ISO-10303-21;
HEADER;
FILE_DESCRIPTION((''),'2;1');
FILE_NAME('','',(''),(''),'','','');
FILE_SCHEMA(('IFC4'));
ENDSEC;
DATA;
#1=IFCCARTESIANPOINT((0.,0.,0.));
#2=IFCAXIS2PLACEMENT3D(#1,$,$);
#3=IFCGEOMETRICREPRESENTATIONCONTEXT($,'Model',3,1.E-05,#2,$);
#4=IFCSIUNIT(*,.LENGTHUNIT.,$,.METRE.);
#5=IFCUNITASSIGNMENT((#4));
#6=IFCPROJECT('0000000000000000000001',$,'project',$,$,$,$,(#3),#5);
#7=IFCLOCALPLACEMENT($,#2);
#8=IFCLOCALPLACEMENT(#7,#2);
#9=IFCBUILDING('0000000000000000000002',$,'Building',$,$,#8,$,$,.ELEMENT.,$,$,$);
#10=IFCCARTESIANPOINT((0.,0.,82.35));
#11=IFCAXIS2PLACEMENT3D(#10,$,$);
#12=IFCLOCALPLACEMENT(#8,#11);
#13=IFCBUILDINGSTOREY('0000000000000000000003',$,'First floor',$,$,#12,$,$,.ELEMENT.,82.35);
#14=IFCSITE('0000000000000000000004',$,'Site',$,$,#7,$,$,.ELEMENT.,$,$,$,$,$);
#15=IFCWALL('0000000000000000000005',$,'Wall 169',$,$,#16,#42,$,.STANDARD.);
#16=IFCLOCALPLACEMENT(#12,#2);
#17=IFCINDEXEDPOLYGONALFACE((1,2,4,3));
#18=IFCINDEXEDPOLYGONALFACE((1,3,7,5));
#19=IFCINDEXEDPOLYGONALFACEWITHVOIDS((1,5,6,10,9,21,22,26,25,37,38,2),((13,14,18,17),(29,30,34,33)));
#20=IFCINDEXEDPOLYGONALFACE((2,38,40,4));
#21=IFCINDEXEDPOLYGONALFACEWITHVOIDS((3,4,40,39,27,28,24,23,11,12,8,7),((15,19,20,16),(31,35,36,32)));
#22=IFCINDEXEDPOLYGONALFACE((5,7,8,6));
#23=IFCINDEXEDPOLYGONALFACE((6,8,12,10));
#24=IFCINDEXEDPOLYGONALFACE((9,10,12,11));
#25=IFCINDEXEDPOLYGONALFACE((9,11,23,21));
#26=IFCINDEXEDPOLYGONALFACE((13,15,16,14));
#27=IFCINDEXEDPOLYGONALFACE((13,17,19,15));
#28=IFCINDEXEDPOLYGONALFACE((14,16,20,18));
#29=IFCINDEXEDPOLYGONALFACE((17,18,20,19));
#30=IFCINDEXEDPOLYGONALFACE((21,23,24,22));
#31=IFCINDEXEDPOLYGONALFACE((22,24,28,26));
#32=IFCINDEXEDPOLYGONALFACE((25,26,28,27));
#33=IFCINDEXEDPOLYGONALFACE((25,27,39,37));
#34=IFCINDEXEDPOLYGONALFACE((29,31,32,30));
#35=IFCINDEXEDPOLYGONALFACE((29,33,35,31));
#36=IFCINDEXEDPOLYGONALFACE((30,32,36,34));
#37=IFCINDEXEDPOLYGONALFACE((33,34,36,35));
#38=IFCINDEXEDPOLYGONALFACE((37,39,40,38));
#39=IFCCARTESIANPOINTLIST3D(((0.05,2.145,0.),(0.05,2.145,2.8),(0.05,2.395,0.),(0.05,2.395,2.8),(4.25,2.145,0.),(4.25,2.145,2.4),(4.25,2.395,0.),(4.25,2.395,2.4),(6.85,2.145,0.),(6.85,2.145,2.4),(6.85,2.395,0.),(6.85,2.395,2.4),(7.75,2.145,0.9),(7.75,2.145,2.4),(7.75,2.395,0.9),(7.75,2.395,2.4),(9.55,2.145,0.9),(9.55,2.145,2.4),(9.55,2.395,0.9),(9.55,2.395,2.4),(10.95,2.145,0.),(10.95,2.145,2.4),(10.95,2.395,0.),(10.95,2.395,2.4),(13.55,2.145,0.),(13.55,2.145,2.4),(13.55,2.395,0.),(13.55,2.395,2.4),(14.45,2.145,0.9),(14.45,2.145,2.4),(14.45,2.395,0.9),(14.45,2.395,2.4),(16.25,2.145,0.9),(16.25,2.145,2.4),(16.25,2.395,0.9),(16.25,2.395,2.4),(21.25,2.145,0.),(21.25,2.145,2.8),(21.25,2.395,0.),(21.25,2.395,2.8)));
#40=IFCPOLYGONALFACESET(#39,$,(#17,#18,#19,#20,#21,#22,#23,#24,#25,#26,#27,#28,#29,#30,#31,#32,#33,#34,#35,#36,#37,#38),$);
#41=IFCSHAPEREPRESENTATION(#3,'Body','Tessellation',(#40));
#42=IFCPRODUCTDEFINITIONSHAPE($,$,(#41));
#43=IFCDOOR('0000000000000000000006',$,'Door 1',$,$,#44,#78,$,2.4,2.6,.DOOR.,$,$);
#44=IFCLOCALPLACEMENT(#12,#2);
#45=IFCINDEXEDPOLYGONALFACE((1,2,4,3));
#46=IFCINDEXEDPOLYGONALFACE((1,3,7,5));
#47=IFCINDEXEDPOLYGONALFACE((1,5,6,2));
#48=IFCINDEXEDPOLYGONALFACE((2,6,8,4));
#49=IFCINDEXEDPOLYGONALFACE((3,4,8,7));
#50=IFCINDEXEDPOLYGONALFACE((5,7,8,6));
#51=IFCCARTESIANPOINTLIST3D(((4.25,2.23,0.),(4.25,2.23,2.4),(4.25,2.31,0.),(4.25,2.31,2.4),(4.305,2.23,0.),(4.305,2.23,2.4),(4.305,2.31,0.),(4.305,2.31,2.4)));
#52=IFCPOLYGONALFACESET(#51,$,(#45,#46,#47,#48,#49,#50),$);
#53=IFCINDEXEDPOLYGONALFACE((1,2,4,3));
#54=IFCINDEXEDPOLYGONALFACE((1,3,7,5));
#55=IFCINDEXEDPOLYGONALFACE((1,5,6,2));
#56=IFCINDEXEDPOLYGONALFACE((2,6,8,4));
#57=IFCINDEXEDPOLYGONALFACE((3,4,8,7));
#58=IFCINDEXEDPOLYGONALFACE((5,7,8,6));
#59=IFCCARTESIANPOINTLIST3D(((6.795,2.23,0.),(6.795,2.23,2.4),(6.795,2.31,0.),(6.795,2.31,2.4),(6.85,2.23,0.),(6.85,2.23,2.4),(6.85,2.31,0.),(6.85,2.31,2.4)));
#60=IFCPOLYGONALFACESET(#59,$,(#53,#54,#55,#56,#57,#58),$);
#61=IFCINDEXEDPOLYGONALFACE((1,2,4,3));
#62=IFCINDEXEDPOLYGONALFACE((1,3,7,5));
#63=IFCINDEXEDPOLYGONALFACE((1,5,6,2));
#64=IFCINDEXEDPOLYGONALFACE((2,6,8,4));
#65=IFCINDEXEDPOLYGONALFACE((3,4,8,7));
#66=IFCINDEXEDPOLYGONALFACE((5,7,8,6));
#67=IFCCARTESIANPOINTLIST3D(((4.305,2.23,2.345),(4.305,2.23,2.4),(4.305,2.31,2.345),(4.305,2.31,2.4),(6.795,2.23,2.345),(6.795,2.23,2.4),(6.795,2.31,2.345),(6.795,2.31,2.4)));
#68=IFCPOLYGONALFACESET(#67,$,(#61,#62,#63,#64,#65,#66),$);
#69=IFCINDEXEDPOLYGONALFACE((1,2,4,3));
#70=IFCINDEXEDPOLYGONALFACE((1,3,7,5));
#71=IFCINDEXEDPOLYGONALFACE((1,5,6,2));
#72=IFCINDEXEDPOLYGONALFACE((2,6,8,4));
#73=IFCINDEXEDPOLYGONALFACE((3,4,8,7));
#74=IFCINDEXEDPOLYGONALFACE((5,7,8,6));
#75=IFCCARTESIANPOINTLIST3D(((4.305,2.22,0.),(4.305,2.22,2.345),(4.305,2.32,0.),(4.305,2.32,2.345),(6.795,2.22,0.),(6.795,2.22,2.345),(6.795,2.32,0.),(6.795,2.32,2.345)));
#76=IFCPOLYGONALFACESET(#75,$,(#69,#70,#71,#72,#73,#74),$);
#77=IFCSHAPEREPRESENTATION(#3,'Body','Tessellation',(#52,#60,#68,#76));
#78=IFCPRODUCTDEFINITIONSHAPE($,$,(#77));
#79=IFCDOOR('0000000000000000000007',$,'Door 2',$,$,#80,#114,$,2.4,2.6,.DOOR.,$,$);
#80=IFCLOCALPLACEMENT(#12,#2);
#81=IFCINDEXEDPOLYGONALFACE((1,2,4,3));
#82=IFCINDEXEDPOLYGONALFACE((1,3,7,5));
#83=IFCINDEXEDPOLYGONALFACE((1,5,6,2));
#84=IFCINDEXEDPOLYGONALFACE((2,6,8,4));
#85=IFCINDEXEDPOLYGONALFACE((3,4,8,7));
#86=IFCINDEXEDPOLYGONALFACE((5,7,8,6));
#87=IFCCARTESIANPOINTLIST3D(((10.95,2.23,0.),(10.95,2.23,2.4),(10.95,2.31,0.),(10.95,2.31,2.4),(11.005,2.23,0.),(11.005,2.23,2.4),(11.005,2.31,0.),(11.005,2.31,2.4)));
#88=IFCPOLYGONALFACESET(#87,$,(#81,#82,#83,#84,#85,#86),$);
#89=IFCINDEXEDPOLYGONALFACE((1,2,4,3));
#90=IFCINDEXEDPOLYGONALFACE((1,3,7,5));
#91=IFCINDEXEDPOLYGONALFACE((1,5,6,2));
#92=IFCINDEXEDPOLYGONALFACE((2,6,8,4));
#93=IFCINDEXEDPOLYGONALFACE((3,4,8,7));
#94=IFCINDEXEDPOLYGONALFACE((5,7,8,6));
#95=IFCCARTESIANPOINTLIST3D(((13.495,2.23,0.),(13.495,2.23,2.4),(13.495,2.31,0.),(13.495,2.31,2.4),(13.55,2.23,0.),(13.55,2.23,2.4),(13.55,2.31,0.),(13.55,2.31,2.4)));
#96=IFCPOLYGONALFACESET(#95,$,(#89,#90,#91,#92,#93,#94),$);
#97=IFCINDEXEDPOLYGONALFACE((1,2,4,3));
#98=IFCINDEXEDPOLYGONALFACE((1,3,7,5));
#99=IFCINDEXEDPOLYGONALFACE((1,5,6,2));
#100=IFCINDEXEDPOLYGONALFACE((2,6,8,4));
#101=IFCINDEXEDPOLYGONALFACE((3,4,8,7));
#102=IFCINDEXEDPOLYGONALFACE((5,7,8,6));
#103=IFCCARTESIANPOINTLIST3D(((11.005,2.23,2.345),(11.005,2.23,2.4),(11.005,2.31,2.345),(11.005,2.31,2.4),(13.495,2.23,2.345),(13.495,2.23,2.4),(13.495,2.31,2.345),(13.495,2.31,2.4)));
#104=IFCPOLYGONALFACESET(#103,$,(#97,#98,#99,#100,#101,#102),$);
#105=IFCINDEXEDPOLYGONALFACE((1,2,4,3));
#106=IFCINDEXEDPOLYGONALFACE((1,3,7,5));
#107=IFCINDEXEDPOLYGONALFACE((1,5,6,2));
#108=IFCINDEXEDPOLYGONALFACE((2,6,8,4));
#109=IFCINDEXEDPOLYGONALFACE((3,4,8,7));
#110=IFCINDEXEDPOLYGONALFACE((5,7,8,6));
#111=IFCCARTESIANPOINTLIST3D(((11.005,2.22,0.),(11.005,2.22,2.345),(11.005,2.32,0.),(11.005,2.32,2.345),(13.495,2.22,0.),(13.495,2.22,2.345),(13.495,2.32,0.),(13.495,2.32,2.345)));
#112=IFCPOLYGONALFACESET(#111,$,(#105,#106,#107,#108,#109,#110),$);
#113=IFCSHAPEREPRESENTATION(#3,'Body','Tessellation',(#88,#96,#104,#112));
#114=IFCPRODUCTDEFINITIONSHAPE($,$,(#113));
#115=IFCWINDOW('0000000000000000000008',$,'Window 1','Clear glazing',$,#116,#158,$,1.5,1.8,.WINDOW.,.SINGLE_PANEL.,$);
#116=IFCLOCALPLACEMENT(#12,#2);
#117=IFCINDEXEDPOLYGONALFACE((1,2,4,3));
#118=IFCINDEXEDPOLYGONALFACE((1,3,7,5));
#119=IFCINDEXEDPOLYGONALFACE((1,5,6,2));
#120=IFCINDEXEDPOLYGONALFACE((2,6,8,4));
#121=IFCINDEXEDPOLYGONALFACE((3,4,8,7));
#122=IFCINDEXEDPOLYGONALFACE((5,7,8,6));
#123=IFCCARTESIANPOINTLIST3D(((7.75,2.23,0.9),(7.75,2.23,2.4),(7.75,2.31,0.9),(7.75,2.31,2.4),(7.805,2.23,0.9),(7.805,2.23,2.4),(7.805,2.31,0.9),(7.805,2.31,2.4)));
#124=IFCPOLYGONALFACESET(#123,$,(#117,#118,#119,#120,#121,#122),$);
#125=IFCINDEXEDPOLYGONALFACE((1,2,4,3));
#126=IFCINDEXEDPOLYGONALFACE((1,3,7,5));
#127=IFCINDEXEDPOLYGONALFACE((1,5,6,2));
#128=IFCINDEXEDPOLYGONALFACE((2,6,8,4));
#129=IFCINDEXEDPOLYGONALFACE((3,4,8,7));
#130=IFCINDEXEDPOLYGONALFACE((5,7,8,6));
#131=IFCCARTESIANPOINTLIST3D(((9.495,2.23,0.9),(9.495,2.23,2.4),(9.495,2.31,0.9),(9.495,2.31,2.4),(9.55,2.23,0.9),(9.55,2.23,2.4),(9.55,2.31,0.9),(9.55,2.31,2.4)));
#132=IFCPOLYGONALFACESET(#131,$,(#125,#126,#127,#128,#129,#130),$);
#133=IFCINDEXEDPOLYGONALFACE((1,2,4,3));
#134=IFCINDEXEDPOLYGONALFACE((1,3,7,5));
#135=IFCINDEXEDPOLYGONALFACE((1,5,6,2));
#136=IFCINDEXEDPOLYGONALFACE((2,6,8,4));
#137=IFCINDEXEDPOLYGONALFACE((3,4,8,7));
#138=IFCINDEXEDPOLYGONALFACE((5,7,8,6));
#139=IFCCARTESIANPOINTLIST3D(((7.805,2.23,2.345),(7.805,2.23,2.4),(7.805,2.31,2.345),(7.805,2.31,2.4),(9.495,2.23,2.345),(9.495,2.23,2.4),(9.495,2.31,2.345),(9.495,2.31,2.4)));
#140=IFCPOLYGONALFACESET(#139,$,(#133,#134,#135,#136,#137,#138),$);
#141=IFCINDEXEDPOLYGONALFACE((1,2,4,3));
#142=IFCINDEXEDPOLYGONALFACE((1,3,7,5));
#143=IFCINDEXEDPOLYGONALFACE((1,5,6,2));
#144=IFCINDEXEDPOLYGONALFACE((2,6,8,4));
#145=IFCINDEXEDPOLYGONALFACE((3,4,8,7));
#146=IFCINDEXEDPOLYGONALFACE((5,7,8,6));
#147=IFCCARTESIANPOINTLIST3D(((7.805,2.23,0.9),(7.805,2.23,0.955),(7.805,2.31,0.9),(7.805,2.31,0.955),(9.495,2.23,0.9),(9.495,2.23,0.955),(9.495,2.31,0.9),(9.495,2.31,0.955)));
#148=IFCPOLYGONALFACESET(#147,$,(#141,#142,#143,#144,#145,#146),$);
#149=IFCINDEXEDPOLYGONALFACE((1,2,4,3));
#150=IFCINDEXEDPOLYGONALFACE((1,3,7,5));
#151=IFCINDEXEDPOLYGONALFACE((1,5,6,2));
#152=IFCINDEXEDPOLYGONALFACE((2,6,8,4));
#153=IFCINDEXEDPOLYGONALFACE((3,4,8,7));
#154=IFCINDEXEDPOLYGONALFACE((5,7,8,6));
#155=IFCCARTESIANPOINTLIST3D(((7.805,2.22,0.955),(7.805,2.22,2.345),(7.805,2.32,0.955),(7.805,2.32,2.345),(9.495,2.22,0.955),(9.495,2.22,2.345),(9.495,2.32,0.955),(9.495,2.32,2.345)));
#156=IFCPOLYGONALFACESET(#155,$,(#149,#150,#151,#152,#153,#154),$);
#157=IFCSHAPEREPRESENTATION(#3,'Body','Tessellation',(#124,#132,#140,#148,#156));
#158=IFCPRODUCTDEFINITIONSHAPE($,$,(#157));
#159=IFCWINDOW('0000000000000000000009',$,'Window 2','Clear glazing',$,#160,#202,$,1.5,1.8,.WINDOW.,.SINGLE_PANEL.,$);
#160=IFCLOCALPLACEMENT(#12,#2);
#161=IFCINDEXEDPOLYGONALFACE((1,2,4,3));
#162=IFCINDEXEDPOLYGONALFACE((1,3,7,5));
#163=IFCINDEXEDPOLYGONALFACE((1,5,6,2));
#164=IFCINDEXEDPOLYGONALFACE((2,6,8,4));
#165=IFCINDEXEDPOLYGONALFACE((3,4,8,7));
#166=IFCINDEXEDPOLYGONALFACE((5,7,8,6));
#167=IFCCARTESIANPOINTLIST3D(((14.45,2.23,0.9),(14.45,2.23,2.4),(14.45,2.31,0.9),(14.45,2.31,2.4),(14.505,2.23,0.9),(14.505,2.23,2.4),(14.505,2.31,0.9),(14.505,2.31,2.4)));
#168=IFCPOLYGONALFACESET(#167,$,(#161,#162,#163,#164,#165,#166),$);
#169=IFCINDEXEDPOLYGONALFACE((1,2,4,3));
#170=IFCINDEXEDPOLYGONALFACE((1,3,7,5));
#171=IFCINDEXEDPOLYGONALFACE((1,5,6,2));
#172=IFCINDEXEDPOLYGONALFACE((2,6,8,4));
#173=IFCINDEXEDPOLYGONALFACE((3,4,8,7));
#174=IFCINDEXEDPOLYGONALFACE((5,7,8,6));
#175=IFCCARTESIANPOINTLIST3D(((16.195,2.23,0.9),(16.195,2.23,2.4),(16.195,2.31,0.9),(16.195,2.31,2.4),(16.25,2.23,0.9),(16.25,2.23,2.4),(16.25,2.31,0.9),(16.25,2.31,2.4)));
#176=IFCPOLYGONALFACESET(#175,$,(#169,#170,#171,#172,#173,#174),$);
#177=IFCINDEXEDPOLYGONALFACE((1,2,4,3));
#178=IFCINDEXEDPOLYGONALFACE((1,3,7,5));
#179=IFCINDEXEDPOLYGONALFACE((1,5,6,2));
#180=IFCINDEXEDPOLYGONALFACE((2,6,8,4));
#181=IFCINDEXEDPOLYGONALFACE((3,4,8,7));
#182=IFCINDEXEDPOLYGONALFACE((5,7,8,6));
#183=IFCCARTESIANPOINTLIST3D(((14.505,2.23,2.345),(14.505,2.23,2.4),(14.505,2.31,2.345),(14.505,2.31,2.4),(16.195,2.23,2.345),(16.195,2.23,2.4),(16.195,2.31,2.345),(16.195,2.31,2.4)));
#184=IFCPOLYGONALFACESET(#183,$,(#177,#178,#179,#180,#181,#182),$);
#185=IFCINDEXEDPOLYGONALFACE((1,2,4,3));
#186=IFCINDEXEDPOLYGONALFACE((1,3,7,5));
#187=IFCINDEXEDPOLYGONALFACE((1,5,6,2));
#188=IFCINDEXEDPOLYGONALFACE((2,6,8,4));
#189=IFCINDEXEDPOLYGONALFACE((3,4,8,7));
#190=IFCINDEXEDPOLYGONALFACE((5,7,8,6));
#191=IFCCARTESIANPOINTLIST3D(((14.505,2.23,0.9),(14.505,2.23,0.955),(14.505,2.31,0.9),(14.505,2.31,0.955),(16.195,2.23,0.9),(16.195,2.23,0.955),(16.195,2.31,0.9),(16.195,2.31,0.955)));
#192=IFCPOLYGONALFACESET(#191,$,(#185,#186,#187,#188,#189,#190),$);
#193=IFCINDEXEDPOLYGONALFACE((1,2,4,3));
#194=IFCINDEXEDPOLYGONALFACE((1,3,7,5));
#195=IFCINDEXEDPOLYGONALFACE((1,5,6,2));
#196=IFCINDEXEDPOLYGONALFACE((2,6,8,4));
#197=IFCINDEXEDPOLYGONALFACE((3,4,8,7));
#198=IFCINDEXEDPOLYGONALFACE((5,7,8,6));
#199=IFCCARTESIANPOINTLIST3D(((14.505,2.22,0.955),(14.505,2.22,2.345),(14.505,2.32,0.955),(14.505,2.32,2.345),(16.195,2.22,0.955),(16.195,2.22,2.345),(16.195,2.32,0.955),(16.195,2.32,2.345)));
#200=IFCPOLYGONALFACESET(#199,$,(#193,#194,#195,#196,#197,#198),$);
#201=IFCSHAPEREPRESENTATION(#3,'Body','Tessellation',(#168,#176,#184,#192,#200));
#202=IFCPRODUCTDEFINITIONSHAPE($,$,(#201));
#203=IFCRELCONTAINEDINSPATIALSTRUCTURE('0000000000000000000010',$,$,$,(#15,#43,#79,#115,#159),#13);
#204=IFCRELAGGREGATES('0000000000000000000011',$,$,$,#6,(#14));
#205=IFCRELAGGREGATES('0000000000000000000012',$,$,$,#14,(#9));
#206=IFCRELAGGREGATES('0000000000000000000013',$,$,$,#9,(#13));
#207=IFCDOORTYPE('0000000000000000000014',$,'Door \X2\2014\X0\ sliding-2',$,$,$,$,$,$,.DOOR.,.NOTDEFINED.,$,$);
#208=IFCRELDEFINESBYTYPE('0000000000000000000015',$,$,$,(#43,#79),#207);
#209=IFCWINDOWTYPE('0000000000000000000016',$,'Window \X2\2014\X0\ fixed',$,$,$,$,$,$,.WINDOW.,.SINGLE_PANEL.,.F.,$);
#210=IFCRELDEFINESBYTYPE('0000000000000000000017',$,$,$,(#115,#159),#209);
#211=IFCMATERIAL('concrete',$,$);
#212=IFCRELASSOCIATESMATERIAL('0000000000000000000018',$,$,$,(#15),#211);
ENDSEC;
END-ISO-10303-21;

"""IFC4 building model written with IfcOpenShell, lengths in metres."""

from ifc_helpers import new_model, si_unit, frame, frame_2d, origin, place, context, project, spatial, rectangle, extrude, material, type_object, element, fill, save


model = new_model("IFC4")

# Units and contexts
model_context = context("Model", 3, precision=1e-05, world=origin())
ifc_project = project(units=[si_unit("LENGTHUNIT", "METRE")], contexts=[model_context])

# Site, building, storey
site_placement = place(None, origin())
site = spatial("IfcSite", under=ifc_project, at=site_placement, Name="Site", CompositionType="ELEMENT")
building_placement = place(site_placement, origin())
building = spatial("IfcBuilding", under=site, at=building_placement, Name="Building", CompositionType="ELEMENT")
storey_placement = place(building_placement, frame((0.0, 0.0, 82.35)))
storey = spatial("IfcBuildingStorey", under=building, at=storey_placement, Name="First floor", CompositionType="ELEMENT", Elevation=82.35)

# Shared definitions
ifc_material = material(Name="concrete")

# Wall, openings, doors, windows
wall_1_placement = place(storey_placement, frame((0.05, 2.27, 0.0), z_axis=(0.0, 0.0, 1.0), x_axis=(1.0, 0.0, 0.0)))
wall_1 = element("IfcWall", 1, at=wall_1_placement, inside=storey, material=ifc_material, Name="Wall 169", PredefinedType="STANDARD", context=model_context, shape_type="SweptSolid", body=[
    extrude(rectangle(XDim=21.2, YDim=0.25, at=frame_2d((10.6, 0.0))), origin(), (0.0, 0.0, 1.0), 2.8),
])
opening_1_placement = place(storey_placement, frame((4.25, 2.27, 0.0), z_axis=(0.0, 0.0, 1.0), x_axis=(1.0, 0.0, 0.0)))
opening_1 = element("IfcOpeningElement", 2, at=opening_1_placement, cuts=wall_1, PredefinedType="OPENING", context=model_context, shape_type="SweptSolid", body=[
    extrude(rectangle(XDim=2.6, YDim=0.31, at=frame_2d((1.3, 0.0))), origin(), (0.0, 0.0, 1.0), 2.4),
])
opening_2_placement = place(storey_placement, frame((7.75, 2.27, 0.9), z_axis=(0.0, 0.0, 1.0), x_axis=(1.0, 0.0, 0.0)))
opening_2 = element("IfcOpeningElement", 3, at=opening_2_placement, cuts=wall_1, PredefinedType="OPENING", context=model_context, shape_type="SweptSolid", body=[
    extrude(rectangle(XDim=1.8, YDim=0.31, at=frame_2d((0.9, 0.0))), origin(), (0.0, 0.0, 1.0), 1.5),
])
opening_3_placement = place(storey_placement, frame((10.95, 2.27, 0.0), z_axis=(0.0, 0.0, 1.0), x_axis=(1.0, 0.0, 0.0)))
opening_3 = element("IfcOpeningElement", 4, at=opening_3_placement, cuts=wall_1, PredefinedType="OPENING", context=model_context, shape_type="SweptSolid", body=[
    extrude(rectangle(XDim=2.6, YDim=0.31, at=frame_2d((1.3, 0.0))), origin(), (0.0, 0.0, 1.0), 2.4),
])
opening_4_placement = place(storey_placement, frame((14.45, 2.27, 0.9), z_axis=(0.0, 0.0, 1.0), x_axis=(1.0, 0.0, 0.0)))
opening_4 = element("IfcOpeningElement", 5, at=opening_4_placement, cuts=wall_1, PredefinedType="OPENING", context=model_context, shape_type="SweptSolid", body=[
    extrude(rectangle(XDim=1.8, YDim=0.31, at=frame_2d((0.9, 0.0))), origin(), (0.0, 0.0, 1.0), 1.5),
])
door_type = type_object("IfcDoorType", Name="Door — sliding-2", PredefinedType="DOOR")
door_1_placement = place(storey_placement, frame((4.25, 2.27, 0.0), z_axis=(0.0, 0.0, 1.0), x_axis=(1.0, 0.0, 0.0)))
door_1 = element("IfcDoor", 6, at=door_1_placement, inside=storey, type_object=door_type, Name="Door 1", OverallHeight=2.4, OverallWidth=2.6, PredefinedType="DOOR", context=model_context, shape_type="SweptSolid", body=[
    extrude(rectangle(XDim=0.055, YDim=0.08, at=frame_2d((0.0275, 0.0))), origin(), (0.0, 0.0, 1.0), 2.4),
    extrude(rectangle(XDim=0.055, YDim=0.08, at=frame_2d((2.5725, 0.0))), origin(), (0.0, 0.0, 1.0), 2.4),
    extrude(rectangle(XDim=2.49, YDim=0.08, at=frame_2d((1.3, 0.0))), frame((0.0, 0.0, 2.345)), (0.0, 0.0, 1.0), 0.055),
    extrude(rectangle(XDim=2.49, YDim=0.1, at=frame_2d((1.3, 0.0))), origin(), (0.0, 0.0, 1.0), 2.345),
])
fill(opening_1, door_1)
door_2_placement = place(storey_placement, frame((10.95, 2.27, 0.0), z_axis=(0.0, 0.0, 1.0), x_axis=(1.0, 0.0, 0.0)))
door_2 = element("IfcDoor", 7, at=door_2_placement, inside=storey, type_object=door_type, Name="Door 2", OverallHeight=2.4, OverallWidth=2.6, PredefinedType="DOOR", context=model_context, shape_type="SweptSolid", body=[
    extrude(rectangle(XDim=0.055, YDim=0.08, at=frame_2d((0.0275, 0.0))), origin(), (0.0, 0.0, 1.0), 2.4),
    extrude(rectangle(XDim=0.055, YDim=0.08, at=frame_2d((2.5725, 0.0))), origin(), (0.0, 0.0, 1.0), 2.4),
    extrude(rectangle(XDim=2.49, YDim=0.08, at=frame_2d((1.3, 0.0))), frame((0.0, 0.0, 2.345)), (0.0, 0.0, 1.0), 0.055),
    extrude(rectangle(XDim=2.49, YDim=0.1, at=frame_2d((1.3, 0.0))), origin(), (0.0, 0.0, 1.0), 2.345),
])
fill(opening_3, door_2)
window_type = type_object("IfcWindowType", Name="Window — fixed", ParameterTakesPrecedence=False, PartitioningType="SINGLE_PANEL", PredefinedType="WINDOW")
window_1_placement = place(storey_placement, frame((7.75, 2.27, 0.9), z_axis=(0.0, 0.0, 1.0), x_axis=(1.0, 0.0, 0.0)))
window_1 = element("IfcWindow", 8, at=window_1_placement, inside=storey, type_object=window_type, Name="Window 1", Description="Clear glazing", OverallHeight=1.5, OverallWidth=1.8, PartitioningType="SINGLE_PANEL", PredefinedType="WINDOW", context=model_context, shape_type="SweptSolid", body=[
    extrude(rectangle(XDim=0.055, YDim=0.08, at=frame_2d((0.0275, 0.0))), origin(), (0.0, 0.0, 1.0), 1.5),
    extrude(rectangle(XDim=0.055, YDim=0.08, at=frame_2d((1.7725, 0.0))), origin(), (0.0, 0.0, 1.0), 1.5),
    extrude(rectangle(XDim=1.69, YDim=0.08, at=frame_2d((0.9, 0.0))), frame((0.0, 0.0, 1.445)), (0.0, 0.0, 1.0), 0.055),
    extrude(rectangle(XDim=1.69, YDim=0.08, at=frame_2d((0.9, 0.0))), origin(), (0.0, 0.0, 1.0), 0.055),
    extrude(rectangle(XDim=1.69, YDim=0.1, at=frame_2d((0.9, 0.0))), frame((0.0, 0.0, 0.055)), (0.0, 0.0, 1.0), 1.39),
])
fill(opening_2, window_1)
window_2_placement = place(storey_placement, frame((14.45, 2.27, 0.9), z_axis=(0.0, 0.0, 1.0), x_axis=(1.0, 0.0, 0.0)))
window_2 = element("IfcWindow", 9, at=window_2_placement, inside=storey, type_object=window_type, Name="Window 2", Description="Clear glazing", OverallHeight=1.5, OverallWidth=1.8, PartitioningType="SINGLE_PANEL", PredefinedType="WINDOW", context=model_context, shape_type="SweptSolid", body=[
    extrude(rectangle(XDim=0.055, YDim=0.08, at=frame_2d((0.0275, 0.0))), origin(), (0.0, 0.0, 1.0), 1.5),
    extrude(rectangle(XDim=0.055, YDim=0.08, at=frame_2d((1.7725, 0.0))), origin(), (0.0, 0.0, 1.0), 1.5),
    extrude(rectangle(XDim=1.69, YDim=0.08, at=frame_2d((0.9, 0.0))), frame((0.0, 0.0, 1.445)), (0.0, 0.0, 1.0), 0.055),
    extrude(rectangle(XDim=1.69, YDim=0.08, at=frame_2d((0.9, 0.0))), origin(), (0.0, 0.0, 1.0), 0.055),
    extrude(rectangle(XDim=1.69, YDim=0.1, at=frame_2d((0.9, 0.0))), frame((0.0, 0.0, 0.055)), (0.0, 0.0, 1.0), 1.39),
])
fill(opening_4, window_2)

save(model, "model.ifc")
